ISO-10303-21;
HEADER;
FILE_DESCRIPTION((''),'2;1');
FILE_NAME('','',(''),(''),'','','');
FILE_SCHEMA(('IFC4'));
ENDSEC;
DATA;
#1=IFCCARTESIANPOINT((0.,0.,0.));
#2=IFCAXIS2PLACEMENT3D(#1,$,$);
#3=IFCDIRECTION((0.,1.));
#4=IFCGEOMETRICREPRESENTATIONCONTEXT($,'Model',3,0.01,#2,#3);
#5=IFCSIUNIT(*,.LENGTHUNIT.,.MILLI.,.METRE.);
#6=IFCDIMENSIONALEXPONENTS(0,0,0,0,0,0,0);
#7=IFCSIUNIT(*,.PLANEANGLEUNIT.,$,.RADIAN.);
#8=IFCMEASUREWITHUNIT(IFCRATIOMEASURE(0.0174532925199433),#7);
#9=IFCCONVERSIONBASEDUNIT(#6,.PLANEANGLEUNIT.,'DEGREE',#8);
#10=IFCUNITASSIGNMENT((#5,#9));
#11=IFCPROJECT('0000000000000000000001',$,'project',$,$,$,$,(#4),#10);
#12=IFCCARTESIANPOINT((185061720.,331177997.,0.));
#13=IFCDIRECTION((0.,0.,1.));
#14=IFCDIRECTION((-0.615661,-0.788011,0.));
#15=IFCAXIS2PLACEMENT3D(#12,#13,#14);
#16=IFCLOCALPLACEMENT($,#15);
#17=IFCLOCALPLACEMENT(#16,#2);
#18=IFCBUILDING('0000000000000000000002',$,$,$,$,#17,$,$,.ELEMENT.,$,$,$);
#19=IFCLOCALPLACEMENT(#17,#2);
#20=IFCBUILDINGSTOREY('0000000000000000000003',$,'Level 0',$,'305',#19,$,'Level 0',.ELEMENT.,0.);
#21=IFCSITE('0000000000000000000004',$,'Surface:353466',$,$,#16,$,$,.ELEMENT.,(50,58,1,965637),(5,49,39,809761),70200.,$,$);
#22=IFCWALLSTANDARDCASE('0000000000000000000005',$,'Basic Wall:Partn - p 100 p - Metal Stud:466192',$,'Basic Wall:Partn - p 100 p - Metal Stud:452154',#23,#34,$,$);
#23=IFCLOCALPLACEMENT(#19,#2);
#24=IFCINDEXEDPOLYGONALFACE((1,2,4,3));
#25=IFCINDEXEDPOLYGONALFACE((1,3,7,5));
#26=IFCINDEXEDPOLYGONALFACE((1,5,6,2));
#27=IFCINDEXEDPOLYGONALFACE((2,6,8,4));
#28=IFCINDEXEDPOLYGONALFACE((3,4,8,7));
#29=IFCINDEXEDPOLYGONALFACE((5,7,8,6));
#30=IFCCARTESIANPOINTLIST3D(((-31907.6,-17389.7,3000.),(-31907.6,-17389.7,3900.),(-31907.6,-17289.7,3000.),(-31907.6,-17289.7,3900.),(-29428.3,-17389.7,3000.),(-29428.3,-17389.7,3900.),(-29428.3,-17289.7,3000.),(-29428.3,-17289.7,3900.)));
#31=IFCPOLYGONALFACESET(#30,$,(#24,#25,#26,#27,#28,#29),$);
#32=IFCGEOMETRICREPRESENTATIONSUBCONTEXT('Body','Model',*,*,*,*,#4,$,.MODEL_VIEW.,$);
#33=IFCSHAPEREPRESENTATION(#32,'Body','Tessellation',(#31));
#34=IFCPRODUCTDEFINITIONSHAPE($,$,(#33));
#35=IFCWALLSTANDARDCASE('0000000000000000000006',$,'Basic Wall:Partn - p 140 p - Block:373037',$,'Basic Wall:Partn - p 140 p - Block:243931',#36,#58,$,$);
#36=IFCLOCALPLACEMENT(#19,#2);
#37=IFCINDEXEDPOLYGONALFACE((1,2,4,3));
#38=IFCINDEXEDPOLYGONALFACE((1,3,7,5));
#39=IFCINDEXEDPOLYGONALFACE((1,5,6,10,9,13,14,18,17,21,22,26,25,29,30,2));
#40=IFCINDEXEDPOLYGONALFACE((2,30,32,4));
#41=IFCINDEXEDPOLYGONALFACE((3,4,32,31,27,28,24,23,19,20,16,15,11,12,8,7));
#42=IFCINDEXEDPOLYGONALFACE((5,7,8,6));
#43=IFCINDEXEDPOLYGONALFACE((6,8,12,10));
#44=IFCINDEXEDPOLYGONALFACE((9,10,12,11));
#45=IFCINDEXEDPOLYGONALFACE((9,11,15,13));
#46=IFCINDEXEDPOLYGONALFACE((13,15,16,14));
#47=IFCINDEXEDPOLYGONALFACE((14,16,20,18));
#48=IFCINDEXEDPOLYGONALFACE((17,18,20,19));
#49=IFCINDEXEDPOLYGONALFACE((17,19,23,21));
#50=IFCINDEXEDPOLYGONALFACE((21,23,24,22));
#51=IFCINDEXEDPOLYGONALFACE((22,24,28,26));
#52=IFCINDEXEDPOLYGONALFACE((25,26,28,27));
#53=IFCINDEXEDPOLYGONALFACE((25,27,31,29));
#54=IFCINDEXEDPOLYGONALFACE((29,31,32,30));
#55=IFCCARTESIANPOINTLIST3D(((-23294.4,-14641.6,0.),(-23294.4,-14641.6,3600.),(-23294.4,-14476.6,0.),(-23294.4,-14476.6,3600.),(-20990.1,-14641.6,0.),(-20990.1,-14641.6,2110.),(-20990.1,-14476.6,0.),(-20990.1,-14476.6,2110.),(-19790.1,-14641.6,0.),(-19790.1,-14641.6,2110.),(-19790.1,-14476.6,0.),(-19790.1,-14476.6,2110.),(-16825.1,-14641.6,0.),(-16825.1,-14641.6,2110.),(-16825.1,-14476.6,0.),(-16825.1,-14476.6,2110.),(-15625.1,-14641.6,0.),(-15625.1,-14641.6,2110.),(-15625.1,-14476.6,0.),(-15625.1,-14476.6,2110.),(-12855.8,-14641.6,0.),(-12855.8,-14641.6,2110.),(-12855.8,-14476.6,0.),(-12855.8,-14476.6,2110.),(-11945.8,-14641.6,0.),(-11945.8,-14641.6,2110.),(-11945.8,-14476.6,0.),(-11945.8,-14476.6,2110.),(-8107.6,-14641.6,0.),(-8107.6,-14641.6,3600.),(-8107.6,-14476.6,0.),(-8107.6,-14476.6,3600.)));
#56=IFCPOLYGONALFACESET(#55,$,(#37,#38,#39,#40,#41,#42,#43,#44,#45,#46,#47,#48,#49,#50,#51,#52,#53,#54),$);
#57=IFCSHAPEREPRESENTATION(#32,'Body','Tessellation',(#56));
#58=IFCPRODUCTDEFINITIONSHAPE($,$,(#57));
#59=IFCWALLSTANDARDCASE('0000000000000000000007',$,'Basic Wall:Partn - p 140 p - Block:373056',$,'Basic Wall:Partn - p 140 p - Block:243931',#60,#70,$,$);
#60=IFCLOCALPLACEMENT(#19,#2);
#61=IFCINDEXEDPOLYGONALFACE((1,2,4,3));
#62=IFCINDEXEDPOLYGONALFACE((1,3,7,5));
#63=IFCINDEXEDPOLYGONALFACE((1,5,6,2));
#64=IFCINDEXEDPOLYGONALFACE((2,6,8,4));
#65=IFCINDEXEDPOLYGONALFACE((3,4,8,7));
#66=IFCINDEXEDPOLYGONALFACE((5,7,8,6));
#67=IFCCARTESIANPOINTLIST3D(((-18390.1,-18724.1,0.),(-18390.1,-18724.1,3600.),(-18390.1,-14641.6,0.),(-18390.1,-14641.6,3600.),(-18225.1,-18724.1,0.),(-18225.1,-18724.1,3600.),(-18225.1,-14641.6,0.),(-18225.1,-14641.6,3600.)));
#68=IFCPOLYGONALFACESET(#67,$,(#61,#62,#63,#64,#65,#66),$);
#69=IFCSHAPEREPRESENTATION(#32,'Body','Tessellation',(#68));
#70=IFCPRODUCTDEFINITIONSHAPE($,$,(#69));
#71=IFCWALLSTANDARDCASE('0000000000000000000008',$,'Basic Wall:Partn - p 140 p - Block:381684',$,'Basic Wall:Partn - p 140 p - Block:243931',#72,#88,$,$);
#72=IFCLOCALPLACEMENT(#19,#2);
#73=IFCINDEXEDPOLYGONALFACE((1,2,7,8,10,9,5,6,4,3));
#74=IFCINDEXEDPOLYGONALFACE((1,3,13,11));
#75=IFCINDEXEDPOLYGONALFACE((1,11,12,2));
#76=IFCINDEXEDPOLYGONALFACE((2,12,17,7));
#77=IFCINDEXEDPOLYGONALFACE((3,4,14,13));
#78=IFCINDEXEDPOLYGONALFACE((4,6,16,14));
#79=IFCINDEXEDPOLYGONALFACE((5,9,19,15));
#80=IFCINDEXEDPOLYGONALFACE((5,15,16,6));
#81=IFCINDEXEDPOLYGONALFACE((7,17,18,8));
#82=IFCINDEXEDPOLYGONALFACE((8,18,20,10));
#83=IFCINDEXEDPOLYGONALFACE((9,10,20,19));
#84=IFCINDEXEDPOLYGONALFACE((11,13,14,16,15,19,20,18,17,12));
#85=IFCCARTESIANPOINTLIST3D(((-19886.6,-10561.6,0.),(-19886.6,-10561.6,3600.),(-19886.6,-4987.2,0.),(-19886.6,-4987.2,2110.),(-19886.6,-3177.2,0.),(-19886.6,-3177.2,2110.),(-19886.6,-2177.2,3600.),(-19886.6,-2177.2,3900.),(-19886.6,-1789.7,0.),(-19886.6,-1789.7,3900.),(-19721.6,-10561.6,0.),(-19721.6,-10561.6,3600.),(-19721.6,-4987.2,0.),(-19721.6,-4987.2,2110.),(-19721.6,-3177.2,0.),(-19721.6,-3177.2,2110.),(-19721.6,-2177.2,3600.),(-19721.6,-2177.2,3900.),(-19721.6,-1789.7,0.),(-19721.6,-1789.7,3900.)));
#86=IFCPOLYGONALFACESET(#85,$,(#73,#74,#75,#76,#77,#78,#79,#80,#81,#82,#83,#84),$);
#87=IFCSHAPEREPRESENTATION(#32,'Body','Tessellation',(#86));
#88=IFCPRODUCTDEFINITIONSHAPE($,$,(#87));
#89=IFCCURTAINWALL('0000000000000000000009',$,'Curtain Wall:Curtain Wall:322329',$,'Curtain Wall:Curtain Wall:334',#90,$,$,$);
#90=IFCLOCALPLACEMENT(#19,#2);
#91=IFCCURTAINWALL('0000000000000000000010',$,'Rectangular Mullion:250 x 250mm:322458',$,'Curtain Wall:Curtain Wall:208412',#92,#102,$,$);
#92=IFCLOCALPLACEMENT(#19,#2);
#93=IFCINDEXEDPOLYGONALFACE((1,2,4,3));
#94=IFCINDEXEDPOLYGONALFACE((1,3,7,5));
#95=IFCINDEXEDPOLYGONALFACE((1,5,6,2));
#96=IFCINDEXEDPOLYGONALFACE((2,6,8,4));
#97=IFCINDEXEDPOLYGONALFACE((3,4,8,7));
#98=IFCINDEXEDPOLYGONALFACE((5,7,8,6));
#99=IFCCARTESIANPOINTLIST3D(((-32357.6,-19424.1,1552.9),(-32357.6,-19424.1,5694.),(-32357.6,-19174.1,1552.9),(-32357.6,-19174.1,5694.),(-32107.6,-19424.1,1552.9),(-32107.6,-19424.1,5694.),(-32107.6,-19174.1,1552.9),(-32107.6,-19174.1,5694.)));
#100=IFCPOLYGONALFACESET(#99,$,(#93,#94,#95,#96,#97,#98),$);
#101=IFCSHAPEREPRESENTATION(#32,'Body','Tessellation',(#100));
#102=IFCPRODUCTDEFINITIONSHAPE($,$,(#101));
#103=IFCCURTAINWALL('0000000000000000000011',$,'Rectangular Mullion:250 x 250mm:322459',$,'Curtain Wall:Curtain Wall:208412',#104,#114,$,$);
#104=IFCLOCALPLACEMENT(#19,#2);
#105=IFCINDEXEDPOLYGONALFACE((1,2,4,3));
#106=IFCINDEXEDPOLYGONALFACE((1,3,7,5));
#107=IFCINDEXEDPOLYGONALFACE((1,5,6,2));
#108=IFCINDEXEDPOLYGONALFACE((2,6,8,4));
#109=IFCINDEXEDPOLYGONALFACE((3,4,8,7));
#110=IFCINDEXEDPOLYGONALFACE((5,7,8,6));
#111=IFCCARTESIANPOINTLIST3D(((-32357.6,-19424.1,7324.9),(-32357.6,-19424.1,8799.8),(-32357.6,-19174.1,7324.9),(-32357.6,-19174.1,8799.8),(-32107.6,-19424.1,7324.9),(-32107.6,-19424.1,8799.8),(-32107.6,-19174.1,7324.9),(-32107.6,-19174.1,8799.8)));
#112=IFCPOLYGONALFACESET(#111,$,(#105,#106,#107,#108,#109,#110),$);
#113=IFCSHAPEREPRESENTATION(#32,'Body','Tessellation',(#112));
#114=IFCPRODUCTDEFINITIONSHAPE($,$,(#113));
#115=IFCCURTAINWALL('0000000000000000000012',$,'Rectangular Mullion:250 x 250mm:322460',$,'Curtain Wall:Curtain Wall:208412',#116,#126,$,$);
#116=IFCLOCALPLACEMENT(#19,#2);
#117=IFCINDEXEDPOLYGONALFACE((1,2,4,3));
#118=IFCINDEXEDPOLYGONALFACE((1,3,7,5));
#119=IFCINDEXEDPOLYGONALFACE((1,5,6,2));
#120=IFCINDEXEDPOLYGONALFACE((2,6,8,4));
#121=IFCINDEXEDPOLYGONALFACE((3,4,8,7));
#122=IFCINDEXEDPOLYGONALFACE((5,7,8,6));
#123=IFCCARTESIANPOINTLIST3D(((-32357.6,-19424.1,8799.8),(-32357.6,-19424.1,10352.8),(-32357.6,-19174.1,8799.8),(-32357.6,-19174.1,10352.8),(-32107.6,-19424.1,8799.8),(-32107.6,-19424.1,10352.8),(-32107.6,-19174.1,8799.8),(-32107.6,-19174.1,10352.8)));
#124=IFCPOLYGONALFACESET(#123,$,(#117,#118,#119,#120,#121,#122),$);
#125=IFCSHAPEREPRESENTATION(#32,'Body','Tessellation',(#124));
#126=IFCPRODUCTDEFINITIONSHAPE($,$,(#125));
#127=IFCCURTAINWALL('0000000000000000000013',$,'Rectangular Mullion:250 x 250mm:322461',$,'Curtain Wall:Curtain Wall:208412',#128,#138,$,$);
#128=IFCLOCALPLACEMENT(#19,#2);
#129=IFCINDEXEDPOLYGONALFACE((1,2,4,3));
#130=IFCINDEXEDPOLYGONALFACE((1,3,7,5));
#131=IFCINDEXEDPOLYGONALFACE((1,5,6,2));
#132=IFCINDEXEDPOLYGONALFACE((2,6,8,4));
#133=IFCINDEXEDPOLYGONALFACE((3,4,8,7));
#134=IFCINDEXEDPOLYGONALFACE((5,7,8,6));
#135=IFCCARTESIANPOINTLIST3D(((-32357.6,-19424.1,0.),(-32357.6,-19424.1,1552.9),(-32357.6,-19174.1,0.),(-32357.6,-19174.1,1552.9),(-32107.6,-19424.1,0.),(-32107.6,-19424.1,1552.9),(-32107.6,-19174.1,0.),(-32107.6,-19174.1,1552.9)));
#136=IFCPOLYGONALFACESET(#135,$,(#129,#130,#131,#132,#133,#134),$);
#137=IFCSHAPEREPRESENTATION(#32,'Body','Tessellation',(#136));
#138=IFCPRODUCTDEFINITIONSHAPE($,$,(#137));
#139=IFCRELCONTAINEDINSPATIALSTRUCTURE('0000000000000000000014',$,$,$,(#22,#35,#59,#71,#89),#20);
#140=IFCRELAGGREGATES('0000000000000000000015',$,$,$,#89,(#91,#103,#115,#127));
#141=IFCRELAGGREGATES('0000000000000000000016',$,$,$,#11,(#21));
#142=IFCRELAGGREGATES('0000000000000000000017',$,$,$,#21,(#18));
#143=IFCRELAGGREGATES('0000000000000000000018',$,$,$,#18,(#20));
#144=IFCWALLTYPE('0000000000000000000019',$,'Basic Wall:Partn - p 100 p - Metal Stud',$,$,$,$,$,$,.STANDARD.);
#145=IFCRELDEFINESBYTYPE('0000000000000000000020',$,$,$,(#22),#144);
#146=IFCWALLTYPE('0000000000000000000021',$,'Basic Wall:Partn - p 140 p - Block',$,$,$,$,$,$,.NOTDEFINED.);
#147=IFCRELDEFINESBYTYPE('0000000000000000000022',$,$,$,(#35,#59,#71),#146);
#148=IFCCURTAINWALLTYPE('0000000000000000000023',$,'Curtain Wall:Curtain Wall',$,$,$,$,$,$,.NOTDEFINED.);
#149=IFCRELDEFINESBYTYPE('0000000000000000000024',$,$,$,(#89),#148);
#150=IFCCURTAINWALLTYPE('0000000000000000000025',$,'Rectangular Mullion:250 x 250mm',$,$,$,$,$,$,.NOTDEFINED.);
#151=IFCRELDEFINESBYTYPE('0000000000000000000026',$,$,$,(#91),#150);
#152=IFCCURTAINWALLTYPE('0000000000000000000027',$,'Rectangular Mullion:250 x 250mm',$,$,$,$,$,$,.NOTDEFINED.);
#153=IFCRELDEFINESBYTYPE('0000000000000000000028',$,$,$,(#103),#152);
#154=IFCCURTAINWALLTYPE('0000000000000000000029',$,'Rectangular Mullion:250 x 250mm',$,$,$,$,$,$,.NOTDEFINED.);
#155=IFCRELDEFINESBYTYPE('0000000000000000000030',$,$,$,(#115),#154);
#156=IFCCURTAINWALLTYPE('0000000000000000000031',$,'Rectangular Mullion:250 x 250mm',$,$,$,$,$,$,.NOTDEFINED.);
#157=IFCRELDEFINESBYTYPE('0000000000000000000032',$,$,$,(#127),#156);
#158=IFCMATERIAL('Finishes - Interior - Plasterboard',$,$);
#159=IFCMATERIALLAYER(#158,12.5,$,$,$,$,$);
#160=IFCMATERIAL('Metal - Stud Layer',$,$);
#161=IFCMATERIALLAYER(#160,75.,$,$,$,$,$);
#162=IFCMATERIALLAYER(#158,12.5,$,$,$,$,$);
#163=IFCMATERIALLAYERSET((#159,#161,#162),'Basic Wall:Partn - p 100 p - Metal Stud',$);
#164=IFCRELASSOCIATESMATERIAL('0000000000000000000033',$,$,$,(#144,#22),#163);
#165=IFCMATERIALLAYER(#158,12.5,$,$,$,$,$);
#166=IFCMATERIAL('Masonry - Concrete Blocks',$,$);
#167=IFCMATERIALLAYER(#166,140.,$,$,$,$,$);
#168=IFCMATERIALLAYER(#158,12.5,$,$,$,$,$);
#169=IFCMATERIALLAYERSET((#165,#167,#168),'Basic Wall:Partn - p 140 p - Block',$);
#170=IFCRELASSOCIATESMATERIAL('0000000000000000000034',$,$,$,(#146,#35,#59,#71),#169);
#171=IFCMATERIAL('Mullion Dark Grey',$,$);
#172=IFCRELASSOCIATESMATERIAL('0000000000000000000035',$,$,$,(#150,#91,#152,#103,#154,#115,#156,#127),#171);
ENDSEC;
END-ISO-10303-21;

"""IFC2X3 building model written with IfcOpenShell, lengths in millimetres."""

from ifc_helpers import new_model, entity, si_unit, converted_unit, direction, frame, frame_2d, origin, origin_2d_with_axis, place, context, subcontext, project, spatial, polyline, rectangle, extrude, clip, bounded_halfspace, source, transform, mapped, material, layer, layer_set, layer_usage, type_object, type_shapes, element, aggregate, save


model = new_model("IFC2X3")

# Units and contexts
model_context = context("Model", 3, precision=0.01, world=origin(), true_north=direction((0.0, 1.0)))
body_context = subcontext(model_context, "Body", "Model", "MODEL_VIEW")
ifc_project = project(units=[si_unit("LENGTHUNIT", "METRE", prefix="MILLI"), converted_unit("PLANEANGLEUNIT", "DEGREE", entity("IfcRatioMeasure", 0.0174532925199433), si_unit("PLANEANGLEUNIT", "RADIAN"), dimensions=[0, 0, 0, 0, 0, 0, 0])], contexts=[model_context])

# Site, building, storey
site_placement = place(None, frame((185061720.0, 331177997.0, 0.0), z_axis=(0.0, 0.0, 1.0), x_axis=(-0.615661, -0.788011, 0.0)))
site = spatial("IfcSite", under=ifc_project, at=site_placement, Name="Surface:353466", CompositionType="ELEMENT", RefLatitude=(50, 58, 1, 965637), RefLongitude=(5, 49, 39, 809761), RefElevation=70200.0)
building_placement = place(site_placement, origin())
building = spatial("IfcBuilding", under=site, at=building_placement, CompositionType="ELEMENT")
storey_placement = place(building_placement, origin())
storey = spatial("IfcBuildingStorey", under=building, at=storey_placement, Name="Level 0", ObjectType="305", LongName="Level 0", CompositionType="ELEMENT", Elevation=0.0)

# Wall
ifc_material_1 = material(Name="Masonry - Concrete Blocks")
ifc_material_2 = material(Name="Finishes - Interior - Plasterboard")
ifc_layer_1 = layer(ifc_material_2, 12.5)
ifc_material_3 = material(Name="Metal - Stud Layer")
ifc_layer_2 = layer(ifc_material_3, 75.0)
ifc_layer_3 = layer(ifc_material_2, 12.5)
ifc_layer_set_1 = layer_set([ifc_layer_1, ifc_layer_2, ifc_layer_3], Name="Basic Wall:Partn - p 100 p - Metal Stud")
ifc_layer_usage_1 = layer_usage(ifc_layer_set_1, "AXIS2", "NEGATIVE", 50.0)
wall_type_1 = type_object("IfcWallType", Name="Basic Wall:Partn - p 100 p - Metal Stud", PredefinedType="STANDARD", material=ifc_layer_set_1)
wall_1_placement = place(storey_placement, frame((-29428.3, -17339.7, 3000.0), z_axis=(0.0, 0.0, 1.0), x_axis=(-1.0, 0.0, 0.0)))
element("IfcWallStandardCase", 1, at=wall_1_placement, inside=storey, type_object=wall_type_1, material=ifc_layer_usage_1, Name="Basic Wall:Partn - p 100 p - Metal Stud:466192", ObjectType="Basic Wall:Partn - p 100 p - Metal Stud:452154", context=body_context, shape_type="SweptSolid", body=[
    extrude(rectangle(XDim=2479.3, YDim=100.0, at=frame_2d((1239.6, 0.0), x_axis=(-1.0, 0.0))), origin(), (0.0, 0.0, 1.0), 900.0),
])

# Wall, openings
ifc_layer_4 = layer(ifc_material_2, 12.5)
ifc_layer_5 = layer(ifc_material_1, 140.0)
ifc_layer_6 = layer(ifc_material_2, 12.5)
ifc_layer_set_2 = layer_set([ifc_layer_4, ifc_layer_5, ifc_layer_6], Name="Basic Wall:Partn - p 140 p - Block")
ifc_layer_usage_2 = layer_usage(ifc_layer_set_2, "AXIS2", "NEGATIVE", 82.5)
wall_type_2 = type_object("IfcWallType", Name="Basic Wall:Partn - p 140 p - Block", PredefinedType="NOTDEFINED", material=ifc_layer_set_2)
wall_2_placement = place(storey_placement, frame((-23294.4, -14559.1, 0.0)))
wall_2 = element("IfcWallStandardCase", 2, at=wall_2_placement, inside=storey, type_object=wall_type_2, material=ifc_layer_usage_2, Name="Basic Wall:Partn - p 140 p - Block:373037", ObjectType="Basic Wall:Partn - p 140 p - Block:243931", context=body_context, shape_type="Clipping", body=[
    clip(extrude(rectangle(XDim=15186.8, YDim=165.0, at=frame_2d((7593.4, 0.0), x_axis=(-1.0, 0.0))), origin(), (0.0, 0.0, 1.0), 3600.0), bounded_halfspace(frame((0.0, 82.5, 3600.0), z_axis=(0.0, 0.0, -1.0), x_axis=(0.0, -1.0, 0.0)), True, frame((0.0, 82.5, 3600.0)), polyline([(0.0, 0.0), (0.0, -165.0), (4904.3, -165.0), (5069.3, -165.0), (9973.6, -165.0), (10138.6, -165.0), (15186.8, -165.0), (15186.8, 0.0), (11516.8, 0.0), (5069.3, 0.0), (4904.3, 0.0), (2173.2, 0.0), (2021.6, 0.0), (0.0, 0.0)]))),
])
opening_1_placement = place(wall_2_placement, frame((2304.3, -82.5, 0.0)))
element("IfcOpeningElement", 3, at=opening_1_placement, cuts=wall_2, ObjectType="Opening", context=body_context, shape_type="SweptSolid", body=[
    extrude(rectangle(XDim=2110.0, YDim=1200.0, at=origin_2d_with_axis()), frame((600.0, 0.0, 1055.0), z_axis=(0.0, 1.0, 0.0), x_axis=(0.0, 0.0, -1.0)), (0.0, 0.0, 1.0), 165.0),
])
opening_2_placement = place(wall_2_placement, frame((6469.3, -82.5, 0.0)))
element("IfcOpeningElement", 4, at=opening_2_placement, cuts=wall_2, ObjectType="Opening", context=body_context, shape_type="SweptSolid", body=[
    extrude(rectangle(XDim=2110.0, YDim=1200.0, at=origin_2d_with_axis()), frame((600.0, 0.0, 1055.0), z_axis=(0.0, 1.0, 0.0), x_axis=(0.0, 0.0, -1.0)), (0.0, 0.0, 1.0), 165.0),
])
opening_3_placement = place(wall_2_placement, frame((10438.6, -1441.5, 0.0)))
element("IfcOpeningElement", 5, at=opening_3_placement, cuts=wall_2, ObjectType="Opening", context=body_context, shape_type="SweptSolid", body=[
    extrude(rectangle(XDim=2110.0, YDim=910.0, at=frame_2d((0.0, 0.0), x_axis=(1.0, 0.0))), frame((455.0, 0.0, 1055.0), z_axis=(0.0, 1.0, 0.0), x_axis=(0.0, 0.0, 1.0)), (0.0, 0.0, 1.0), 3048.0),
])
opening_4_placement = place(wall_2_placement, frame((11348.6, 82.5, 0.0)))
element("IfcOpeningElement", 6, at=opening_4_placement, cuts=wall_2, ObjectType="Opening", context=body_context, shape_type="SweptSolid", body=[
    extrude(rectangle(XDim=2110.0, YDim=910.0, at=frame_2d((1055.0, 455.0), x_axis=(1.0, 0.0))), frame((0.0, 0.0, 0.0), z_axis=(0.0, -1.0, 0.0), x_axis=(0.0, 0.0, 1.0)), (0.0, 0.0, 1.0), 165.0),
])

# Wall
ifc_layer_usage_3 = layer_usage(ifc_layer_set_2, "AXIS2", "NEGATIVE", 82.5)
wall_3_placement = place(storey_placement, frame((-18307.6, -14641.6, 0.0), z_axis=(0.0, 0.0, 1.0), x_axis=(0.0, -1.0, 0.0)))
element("IfcWallStandardCase", 7, at=wall_3_placement, inside=storey, type_object=wall_type_2, material=ifc_layer_usage_3, Name="Basic Wall:Partn - p 140 p - Block:373056", ObjectType="Basic Wall:Partn - p 140 p - Block:243931", context=body_context, shape_type="Clipping", body=[
    clip(extrude(rectangle(XDim=4082.5, YDim=165.0, at=frame_2d((2041.2, 0.0), x_axis=(-1.0, 0.0))), origin(), (0.0, 0.0, 1.0), 3600.0), bounded_halfspace(frame((0.0, -82.5, 3600.0), z_axis=(0.0, 0.0, -1.0), x_axis=(1.0, 0.0, 0.0)), True, frame((0.0, -82.5, 3600.0)), polyline([(0.0, 0.0), (4082.5, 0.0), (4082.5, 165.0), (0.0, 165.0), (0.0, 0.0)]))),
])

# Wall, openings
ifc_layer_usage_4 = layer_usage(ifc_layer_set_2, "AXIS2", "NEGATIVE", 82.5)
wall_4_placement = place(storey_placement, frame((-19804.1, -10561.6, 0.0), z_axis=(0.0, 0.0, 1.0), x_axis=(0.0, 1.0, 0.0)))
wall_4 = element("IfcWallStandardCase", 8, at=wall_4_placement, inside=storey, type_object=wall_type_2, material=ifc_layer_usage_4, Name="Basic Wall:Partn - p 140 p - Block:381684", ObjectType="Basic Wall:Partn - p 140 p - Block:243931", context=body_context, shape_type="Clipping", body=[
    clip(clip(extrude(rectangle(XDim=8771.9, YDim=165.0, at=frame_2d((4385.9, 0.0), x_axis=(-1.0, 0.0))), origin(), (0.0, 0.0, 1.0), 3900.0), bounded_halfspace(frame((8771.9, -82.5, 3900.0), z_axis=(0.0, 0.0, -1.0), x_axis=(0.0, -1.0, 0.0)), True, frame((8771.9, -82.5, 3900.0)), polyline([(0.0, 0.0), (0.0, 165.0), (-387.5, 165.0), (-387.5, 0.0), (0.0, 0.0)]))), bounded_halfspace(frame((0.0, 82.5, 3600.0), z_axis=(0.0, 0.0, -1.0), x_axis=(-1.0, 0.0, 0.0)), True, frame((0.0, 82.5, 3600.0)), polyline([(0.0, 0.0), (0.0, -165.0), (8384.4, -165.0), (8384.4, 0.0), (0.0, 0.0)]))),
])
opening_5_placement = place(wall_4_placement, frame((5574.4, 1441.5, 0.0)))
element("IfcOpeningElement", 9, at=opening_5_placement, cuts=wall_4, ObjectType="Opening", context=body_context, shape_type="SweptSolid", body=[
    extrude(rectangle(XDim=2110.0, YDim=1810.0, at=frame_2d((0.0, 0.0), x_axis=(0.0, 1.0))), frame((905.0, -3048.0, 1055.0), z_axis=(0.0, 1.0, 0.0), x_axis=(-1.0, 0.0, 0.0)), (0.0, 0.0, 1.0), 3048.0),
])
opening_6_placement = place(wall_4_placement, frame((5574.4, -82.5, 0.0)))
element("IfcOpeningElement", 10, at=opening_6_placement, cuts=wall_4, ObjectType="Opening", context=body_context, shape_type="SweptSolid", body=[
    extrude(rectangle(XDim=2110.0, YDim=1810.0, at=frame_2d((1055.0, 905.0), x_axis=(1.0, 0.0))), frame((0.0, 0.0, 0.0), z_axis=(0.0, 1.0, 0.0), x_axis=(0.0, 0.0, 1.0)), (0.0, 0.0, 1.0), 165.0),
])

# Curtain walls
curtain_wall_type_1 = type_object("IfcCurtainWallType", Name="Curtain Wall:Curtain Wall", PredefinedType="NOTDEFINED")
curtain_wall_1_placement = place(storey_placement, origin())
curtain_wall_1 = element("IfcCurtainWall", 11, at=curtain_wall_1_placement, inside=storey, type_object=curtain_wall_type_1, Name="Curtain Wall:Curtain Wall:322329", ObjectType="Curtain Wall:Curtain Wall:334")
ifc_material_4 = material(Name="Mullion Dark Grey")
curtain_wall_type_2 = type_object("IfcCurtainWallType", Name="Rectangular Mullion:250 x 250mm", PredefinedType="NOTDEFINED", material=ifc_material_4)
shared_shape_1 = source(origin(), body_context, "Body", "SweptSolid", [
    extrude(rectangle(XDim=250.0, YDim=250.0, at=origin_2d_with_axis()), frame((-125.0, 0.0, -4141.1), z_axis=(0.0, 0.0, 1.0), x_axis=(-1.0, 0.0, 0.0)), (0.0, 0.0, 1.0), 4141.1),
])
type_shapes(curtain_wall_type_2, [shared_shape_1])
curtain_wall_2_placement = place(storey_placement, frame((-32107.6, -19299.1, 5694.0)))
curtain_wall_2 = element("IfcCurtainWall", 12, at=curtain_wall_2_placement, type_object=curtain_wall_type_2, material=ifc_material_4, Name="Rectangular Mullion:250 x 250mm:322458", ObjectType="Curtain Wall:Curtain Wall:208412", context=body_context, shape_type="MappedRepresentation", body=[
    mapped(shared_shape_1, transform((0.0, 0.0, 0.0), scale=1.0)),
])
curtain_wall_type_3 = type_object("IfcCurtainWallType", Name="Rectangular Mullion:250 x 250mm", PredefinedType="NOTDEFINED", material=ifc_material_4)
shared_shape_2 = source(origin(), body_context, "Body", "SweptSolid", [
    extrude(rectangle(XDim=250.0, YDim=250.0, at=origin_2d_with_axis()), frame((-125.0, 0.0, -1474.9), z_axis=(0.0, 0.0, 1.0), x_axis=(-1.0, 0.0, 0.0)), (0.0, 0.0, 1.0), 1474.9),
])
type_shapes(curtain_wall_type_3, [shared_shape_2])
curtain_wall_3_placement = place(storey_placement, frame((-32107.6, -19299.1, 8799.8)))
curtain_wall_3 = element("IfcCurtainWall", 13, at=curtain_wall_3_placement, type_object=curtain_wall_type_3, material=ifc_material_4, Name="Rectangular Mullion:250 x 250mm:322459", ObjectType="Curtain Wall:Curtain Wall:208412", context=body_context, shape_type="MappedRepresentation", body=[
    mapped(shared_shape_2, transform((0.0, 0.0, 0.0), scale=1.0)),
])
curtain_wall_type_4 = type_object("IfcCurtainWallType", Name="Rectangular Mullion:250 x 250mm", PredefinedType="NOTDEFINED", material=ifc_material_4)
shared_shape_3 = source(origin(), body_context, "Body", "SweptSolid", [
    extrude(rectangle(XDim=250.0, YDim=250.0, at=origin_2d_with_axis()), frame((-125.0, 0.0, -1552.9), z_axis=(0.0, 0.0, 1.0), x_axis=(-1.0, 0.0, 0.0)), (0.0, 0.0, 1.0), 1552.9),
])
type_shapes(curtain_wall_type_4, [shared_shape_3])
curtain_wall_4_placement = place(storey_placement, frame((-32107.6, -19299.1, 10352.8)))
curtain_wall_4 = element("IfcCurtainWall", 14, at=curtain_wall_4_placement, type_object=curtain_wall_type_4, material=ifc_material_4, Name="Rectangular Mullion:250 x 250mm:322460", ObjectType="Curtain Wall:Curtain Wall:208412", context=body_context, shape_type="MappedRepresentation", body=[
    mapped(shared_shape_3, transform((0.0, 0.0, 0.0), scale=1.0)),
])
curtain_wall_type_5 = type_object("IfcCurtainWallType", Name="Rectangular Mullion:250 x 250mm", PredefinedType="NOTDEFINED", material=ifc_material_4)
shared_shape_4 = source(origin(), body_context, "Body", "SweptSolid", [
    extrude(rectangle(XDim=250.0, YDim=250.0, at=origin_2d_with_axis()), frame((-125.0, 0.0, -1552.9), z_axis=(0.0, 0.0, 1.0), x_axis=(-1.0, 0.0, 0.0)), (0.0, 0.0, 1.0), 1552.9),
])
type_shapes(curtain_wall_type_5, [shared_shape_4])
curtain_wall_5_placement = place(storey_placement, frame((-32107.6, -19299.1, 1552.9)))
curtain_wall_5 = element("IfcCurtainWall", 15, at=curtain_wall_5_placement, type_object=curtain_wall_type_5, material=ifc_material_4, Name="Rectangular Mullion:250 x 250mm:322461", ObjectType="Curtain Wall:Curtain Wall:208412", context=body_context, shape_type="MappedRepresentation", body=[
    mapped(shared_shape_4, transform((0.0, 0.0, 0.0), scale=1.0)),
])
aggregate(curtain_wall_1, [curtain_wall_2, curtain_wall_3, curtain_wall_4, curtain_wall_5])

save(model, "model.ifc")
